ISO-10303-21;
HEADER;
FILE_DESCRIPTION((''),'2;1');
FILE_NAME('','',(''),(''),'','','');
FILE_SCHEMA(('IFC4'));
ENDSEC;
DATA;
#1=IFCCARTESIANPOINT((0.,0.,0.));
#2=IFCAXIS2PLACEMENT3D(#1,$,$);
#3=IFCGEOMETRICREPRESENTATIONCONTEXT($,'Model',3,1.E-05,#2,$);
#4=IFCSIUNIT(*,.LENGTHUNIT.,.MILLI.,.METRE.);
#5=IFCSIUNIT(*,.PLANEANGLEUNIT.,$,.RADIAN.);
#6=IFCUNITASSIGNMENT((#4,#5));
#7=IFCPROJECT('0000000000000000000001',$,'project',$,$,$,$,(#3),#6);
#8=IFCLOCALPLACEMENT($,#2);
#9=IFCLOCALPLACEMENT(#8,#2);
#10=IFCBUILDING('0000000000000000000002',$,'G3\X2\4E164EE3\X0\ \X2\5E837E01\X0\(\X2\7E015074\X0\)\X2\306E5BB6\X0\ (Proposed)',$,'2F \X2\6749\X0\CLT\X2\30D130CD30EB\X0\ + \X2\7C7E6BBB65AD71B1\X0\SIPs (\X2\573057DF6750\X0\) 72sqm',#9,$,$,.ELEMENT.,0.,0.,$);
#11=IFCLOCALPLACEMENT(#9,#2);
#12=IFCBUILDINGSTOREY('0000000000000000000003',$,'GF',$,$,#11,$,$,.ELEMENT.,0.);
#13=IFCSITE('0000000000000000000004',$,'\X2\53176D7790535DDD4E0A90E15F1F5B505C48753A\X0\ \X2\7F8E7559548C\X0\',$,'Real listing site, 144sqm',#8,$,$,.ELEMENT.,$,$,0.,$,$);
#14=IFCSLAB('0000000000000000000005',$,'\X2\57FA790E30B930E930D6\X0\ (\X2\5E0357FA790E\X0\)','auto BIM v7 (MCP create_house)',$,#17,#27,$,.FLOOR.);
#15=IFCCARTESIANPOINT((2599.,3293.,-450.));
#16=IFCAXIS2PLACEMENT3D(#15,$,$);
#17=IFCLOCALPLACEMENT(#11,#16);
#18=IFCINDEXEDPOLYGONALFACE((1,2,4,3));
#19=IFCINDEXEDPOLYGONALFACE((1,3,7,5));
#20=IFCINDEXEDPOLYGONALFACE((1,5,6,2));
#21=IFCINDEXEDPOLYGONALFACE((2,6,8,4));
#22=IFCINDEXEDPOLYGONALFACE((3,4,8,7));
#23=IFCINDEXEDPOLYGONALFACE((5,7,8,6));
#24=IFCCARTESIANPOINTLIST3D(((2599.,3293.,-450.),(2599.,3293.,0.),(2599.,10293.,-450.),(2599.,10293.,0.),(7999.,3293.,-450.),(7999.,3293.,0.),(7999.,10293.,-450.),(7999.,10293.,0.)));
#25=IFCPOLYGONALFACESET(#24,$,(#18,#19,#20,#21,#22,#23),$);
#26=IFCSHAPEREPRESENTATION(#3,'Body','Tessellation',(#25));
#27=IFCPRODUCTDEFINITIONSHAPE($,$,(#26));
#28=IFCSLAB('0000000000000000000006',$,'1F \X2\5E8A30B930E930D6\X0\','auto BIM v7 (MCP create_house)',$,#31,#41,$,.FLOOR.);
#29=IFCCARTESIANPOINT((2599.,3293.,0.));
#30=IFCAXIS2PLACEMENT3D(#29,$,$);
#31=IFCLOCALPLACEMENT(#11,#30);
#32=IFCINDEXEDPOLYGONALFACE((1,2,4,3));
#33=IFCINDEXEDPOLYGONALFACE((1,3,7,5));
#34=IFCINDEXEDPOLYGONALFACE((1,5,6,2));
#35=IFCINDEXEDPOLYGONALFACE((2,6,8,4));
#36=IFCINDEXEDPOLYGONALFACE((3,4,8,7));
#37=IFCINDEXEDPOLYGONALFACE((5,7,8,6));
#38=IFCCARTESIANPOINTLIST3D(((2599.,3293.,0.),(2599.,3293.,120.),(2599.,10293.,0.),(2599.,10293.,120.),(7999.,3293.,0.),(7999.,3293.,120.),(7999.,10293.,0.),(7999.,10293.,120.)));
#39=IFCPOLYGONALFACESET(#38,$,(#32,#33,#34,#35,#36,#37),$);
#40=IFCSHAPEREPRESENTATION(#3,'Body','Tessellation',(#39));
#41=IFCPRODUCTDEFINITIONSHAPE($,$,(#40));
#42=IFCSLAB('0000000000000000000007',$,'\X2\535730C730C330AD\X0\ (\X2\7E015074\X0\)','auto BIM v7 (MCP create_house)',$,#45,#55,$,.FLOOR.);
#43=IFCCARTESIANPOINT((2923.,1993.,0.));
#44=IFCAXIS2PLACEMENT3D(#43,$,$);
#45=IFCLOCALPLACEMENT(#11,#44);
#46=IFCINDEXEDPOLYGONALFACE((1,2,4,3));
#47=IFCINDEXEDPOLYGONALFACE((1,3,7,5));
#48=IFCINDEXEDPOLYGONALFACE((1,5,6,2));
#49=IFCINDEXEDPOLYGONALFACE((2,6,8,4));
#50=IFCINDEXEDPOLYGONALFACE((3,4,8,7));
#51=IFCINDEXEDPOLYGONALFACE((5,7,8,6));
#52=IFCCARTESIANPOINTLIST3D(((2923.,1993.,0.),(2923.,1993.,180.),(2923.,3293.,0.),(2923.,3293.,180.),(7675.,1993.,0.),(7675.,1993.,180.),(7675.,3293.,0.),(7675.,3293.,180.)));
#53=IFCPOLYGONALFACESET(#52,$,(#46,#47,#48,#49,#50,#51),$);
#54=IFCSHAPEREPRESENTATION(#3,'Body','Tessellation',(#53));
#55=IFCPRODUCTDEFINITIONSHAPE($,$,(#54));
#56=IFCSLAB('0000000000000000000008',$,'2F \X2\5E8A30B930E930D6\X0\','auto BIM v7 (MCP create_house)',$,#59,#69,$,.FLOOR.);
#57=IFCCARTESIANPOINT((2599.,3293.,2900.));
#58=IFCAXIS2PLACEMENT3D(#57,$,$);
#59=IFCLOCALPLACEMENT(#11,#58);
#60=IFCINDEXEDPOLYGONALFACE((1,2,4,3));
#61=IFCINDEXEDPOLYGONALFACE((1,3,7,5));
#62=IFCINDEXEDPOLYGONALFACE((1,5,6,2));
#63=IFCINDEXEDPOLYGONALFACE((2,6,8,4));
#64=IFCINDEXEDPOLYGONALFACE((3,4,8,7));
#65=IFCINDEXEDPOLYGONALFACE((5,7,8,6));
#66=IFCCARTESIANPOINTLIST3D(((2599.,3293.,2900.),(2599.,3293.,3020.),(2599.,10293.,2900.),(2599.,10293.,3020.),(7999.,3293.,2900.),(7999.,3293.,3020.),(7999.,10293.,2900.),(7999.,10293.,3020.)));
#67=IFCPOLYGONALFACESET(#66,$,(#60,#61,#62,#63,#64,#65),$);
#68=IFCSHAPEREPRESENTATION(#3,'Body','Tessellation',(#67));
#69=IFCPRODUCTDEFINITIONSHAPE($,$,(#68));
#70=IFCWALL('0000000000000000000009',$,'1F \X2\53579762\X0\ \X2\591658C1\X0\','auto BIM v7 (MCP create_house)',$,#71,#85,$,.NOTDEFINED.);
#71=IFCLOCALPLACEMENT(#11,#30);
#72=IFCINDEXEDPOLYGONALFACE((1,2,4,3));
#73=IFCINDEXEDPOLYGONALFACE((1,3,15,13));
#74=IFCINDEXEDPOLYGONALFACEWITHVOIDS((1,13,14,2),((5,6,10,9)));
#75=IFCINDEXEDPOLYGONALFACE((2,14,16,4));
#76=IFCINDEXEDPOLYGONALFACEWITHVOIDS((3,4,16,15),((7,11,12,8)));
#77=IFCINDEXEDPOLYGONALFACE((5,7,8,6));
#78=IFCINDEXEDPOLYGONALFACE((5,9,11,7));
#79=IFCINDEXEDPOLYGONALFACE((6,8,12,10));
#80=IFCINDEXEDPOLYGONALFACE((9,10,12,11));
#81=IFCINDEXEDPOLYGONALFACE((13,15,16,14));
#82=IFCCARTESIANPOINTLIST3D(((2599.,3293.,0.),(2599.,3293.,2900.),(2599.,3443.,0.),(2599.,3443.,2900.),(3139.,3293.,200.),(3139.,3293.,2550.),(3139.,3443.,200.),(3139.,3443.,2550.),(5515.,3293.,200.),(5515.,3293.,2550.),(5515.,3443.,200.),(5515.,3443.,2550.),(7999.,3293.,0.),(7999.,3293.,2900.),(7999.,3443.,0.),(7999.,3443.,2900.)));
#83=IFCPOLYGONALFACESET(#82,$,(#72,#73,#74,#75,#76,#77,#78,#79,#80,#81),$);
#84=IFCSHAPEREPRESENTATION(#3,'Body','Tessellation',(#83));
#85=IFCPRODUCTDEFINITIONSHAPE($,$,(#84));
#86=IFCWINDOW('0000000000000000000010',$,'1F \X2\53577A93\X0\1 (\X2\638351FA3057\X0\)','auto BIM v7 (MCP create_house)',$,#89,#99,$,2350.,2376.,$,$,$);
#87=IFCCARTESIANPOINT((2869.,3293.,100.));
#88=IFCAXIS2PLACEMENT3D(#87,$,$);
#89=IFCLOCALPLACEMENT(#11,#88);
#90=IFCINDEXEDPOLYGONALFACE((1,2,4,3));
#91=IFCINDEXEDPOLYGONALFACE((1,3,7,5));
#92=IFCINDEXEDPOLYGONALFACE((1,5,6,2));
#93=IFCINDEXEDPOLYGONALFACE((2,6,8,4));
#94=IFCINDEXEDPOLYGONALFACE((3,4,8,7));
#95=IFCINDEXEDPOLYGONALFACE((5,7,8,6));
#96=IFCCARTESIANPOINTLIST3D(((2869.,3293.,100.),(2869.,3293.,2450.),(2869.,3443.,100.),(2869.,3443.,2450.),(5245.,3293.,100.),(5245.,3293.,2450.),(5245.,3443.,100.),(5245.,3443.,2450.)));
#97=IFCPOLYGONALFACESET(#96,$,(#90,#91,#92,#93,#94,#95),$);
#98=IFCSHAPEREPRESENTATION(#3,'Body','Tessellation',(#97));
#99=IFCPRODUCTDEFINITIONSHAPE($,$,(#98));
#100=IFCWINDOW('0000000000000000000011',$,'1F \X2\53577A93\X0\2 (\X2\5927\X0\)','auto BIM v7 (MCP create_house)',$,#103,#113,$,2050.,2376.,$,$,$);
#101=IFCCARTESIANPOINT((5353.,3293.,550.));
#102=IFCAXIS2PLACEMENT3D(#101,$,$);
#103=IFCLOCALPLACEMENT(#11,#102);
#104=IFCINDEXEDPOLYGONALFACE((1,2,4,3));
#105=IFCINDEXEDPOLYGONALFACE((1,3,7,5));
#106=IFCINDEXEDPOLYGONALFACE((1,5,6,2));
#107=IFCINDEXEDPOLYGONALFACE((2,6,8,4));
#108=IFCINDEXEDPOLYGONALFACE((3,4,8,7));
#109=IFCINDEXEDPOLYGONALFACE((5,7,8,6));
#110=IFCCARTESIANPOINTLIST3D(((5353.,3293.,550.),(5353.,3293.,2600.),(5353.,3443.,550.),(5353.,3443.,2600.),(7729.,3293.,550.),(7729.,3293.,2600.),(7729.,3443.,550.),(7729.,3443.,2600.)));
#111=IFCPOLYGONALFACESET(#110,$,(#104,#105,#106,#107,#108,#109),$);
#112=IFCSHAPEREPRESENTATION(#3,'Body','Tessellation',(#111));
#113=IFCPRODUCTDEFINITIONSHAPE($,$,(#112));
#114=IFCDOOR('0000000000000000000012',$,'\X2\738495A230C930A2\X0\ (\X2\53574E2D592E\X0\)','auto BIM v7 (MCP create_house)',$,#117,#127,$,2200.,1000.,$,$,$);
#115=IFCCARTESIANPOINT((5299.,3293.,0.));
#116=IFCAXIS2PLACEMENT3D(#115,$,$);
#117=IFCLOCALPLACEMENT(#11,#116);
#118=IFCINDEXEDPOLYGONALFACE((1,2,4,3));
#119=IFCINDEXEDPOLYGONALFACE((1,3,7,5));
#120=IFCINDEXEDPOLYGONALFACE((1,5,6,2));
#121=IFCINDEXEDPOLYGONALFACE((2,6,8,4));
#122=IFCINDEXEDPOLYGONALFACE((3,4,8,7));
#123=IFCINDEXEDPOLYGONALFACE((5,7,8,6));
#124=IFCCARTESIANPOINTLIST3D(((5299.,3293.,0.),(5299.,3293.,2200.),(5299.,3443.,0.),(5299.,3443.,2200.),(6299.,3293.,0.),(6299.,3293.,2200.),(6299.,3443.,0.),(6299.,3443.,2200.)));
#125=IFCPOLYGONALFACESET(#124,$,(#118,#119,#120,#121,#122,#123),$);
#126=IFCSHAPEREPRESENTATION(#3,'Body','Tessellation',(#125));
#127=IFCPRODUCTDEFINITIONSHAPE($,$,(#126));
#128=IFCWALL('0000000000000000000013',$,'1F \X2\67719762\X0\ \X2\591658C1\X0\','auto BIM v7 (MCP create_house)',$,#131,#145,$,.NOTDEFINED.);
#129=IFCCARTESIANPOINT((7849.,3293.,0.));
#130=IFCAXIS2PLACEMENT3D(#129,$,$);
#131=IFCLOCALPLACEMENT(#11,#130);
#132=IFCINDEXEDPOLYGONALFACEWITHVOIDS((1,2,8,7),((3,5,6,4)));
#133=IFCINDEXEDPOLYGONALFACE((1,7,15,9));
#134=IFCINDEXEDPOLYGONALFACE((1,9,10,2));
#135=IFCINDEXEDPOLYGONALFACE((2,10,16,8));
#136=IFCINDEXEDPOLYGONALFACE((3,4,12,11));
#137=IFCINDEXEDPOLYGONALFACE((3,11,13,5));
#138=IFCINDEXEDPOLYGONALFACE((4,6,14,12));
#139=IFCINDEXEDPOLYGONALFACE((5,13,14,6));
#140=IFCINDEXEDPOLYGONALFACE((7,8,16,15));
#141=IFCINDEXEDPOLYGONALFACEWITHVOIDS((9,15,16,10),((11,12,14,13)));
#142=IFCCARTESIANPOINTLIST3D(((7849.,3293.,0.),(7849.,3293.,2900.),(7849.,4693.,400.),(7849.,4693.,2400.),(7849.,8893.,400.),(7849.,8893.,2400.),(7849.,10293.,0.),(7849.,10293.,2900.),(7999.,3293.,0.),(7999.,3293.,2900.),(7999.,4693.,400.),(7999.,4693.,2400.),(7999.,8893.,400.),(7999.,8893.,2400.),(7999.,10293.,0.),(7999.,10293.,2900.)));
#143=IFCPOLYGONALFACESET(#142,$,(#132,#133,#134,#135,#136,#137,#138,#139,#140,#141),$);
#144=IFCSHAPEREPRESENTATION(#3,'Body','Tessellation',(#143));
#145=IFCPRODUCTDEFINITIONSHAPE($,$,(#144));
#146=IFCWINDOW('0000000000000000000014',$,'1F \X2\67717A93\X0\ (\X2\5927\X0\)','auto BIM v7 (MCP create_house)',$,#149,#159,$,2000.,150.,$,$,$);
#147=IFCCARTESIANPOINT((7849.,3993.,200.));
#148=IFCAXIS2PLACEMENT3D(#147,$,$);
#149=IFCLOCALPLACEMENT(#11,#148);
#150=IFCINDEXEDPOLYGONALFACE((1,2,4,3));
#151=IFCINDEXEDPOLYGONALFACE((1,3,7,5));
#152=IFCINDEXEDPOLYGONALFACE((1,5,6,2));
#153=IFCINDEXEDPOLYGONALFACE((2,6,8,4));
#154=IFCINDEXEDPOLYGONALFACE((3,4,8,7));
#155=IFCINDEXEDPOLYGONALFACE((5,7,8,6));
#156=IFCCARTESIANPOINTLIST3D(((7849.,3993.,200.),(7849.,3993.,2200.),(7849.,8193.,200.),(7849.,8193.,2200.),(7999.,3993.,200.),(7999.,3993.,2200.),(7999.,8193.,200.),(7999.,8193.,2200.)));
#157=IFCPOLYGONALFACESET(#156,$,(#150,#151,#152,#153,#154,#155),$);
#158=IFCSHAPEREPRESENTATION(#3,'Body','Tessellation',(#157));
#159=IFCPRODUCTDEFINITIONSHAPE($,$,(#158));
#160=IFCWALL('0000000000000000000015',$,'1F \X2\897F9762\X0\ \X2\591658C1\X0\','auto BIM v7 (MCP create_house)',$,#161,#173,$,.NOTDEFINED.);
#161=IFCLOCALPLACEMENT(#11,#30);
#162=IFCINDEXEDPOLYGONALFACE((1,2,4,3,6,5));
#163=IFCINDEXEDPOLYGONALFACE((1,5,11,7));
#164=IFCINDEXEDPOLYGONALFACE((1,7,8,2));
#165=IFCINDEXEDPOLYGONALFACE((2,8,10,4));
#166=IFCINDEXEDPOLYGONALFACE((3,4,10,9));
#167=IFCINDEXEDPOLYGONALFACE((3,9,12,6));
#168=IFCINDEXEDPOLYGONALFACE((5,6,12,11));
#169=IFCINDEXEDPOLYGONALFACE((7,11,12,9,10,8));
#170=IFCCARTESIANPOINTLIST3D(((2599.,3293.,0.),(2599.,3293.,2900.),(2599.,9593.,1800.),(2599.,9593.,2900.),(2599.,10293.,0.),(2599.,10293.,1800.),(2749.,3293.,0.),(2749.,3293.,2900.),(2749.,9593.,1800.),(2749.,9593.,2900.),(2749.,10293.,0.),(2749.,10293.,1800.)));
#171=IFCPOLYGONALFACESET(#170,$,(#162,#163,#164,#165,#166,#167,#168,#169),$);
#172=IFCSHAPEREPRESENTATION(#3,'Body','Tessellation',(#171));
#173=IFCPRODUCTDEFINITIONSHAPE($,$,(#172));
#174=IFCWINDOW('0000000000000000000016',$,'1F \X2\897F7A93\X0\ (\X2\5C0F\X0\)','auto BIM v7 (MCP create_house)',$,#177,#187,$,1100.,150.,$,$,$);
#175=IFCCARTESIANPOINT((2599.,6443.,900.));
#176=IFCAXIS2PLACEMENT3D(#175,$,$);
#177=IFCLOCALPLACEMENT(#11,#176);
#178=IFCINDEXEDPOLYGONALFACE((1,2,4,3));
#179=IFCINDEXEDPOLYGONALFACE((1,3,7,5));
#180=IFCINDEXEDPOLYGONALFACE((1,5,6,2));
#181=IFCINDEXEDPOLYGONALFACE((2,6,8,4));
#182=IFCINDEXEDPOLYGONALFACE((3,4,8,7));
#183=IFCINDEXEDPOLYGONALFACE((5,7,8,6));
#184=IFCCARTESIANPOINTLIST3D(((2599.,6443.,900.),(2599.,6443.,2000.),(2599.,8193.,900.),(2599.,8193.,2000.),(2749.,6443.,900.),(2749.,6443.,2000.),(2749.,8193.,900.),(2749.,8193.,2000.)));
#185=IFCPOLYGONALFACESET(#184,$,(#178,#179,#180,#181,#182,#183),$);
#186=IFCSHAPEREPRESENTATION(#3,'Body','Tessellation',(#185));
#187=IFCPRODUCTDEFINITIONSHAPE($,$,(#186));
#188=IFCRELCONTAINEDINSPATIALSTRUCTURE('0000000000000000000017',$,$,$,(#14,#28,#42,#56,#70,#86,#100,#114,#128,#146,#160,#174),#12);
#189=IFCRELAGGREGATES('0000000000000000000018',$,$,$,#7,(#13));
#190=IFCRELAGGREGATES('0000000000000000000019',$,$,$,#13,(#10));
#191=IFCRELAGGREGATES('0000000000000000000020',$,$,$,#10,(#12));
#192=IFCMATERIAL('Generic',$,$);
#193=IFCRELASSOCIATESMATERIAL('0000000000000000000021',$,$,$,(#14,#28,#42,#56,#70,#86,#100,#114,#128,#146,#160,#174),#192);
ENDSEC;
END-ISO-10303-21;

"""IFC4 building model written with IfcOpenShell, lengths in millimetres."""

from ifc_helpers import new_model, si_unit, frame, frame_2d, origin, place, context, project, spatial, rectangle, extrude, material, element, fill, save


model = new_model("IFC4")

# Units and contexts
model_context = context("Model", 3, precision=1e-05, world=origin())
ifc_project = project(units=[si_unit("LENGTHUNIT", "METRE", prefix="MILLI"), si_unit("PLANEANGLEUNIT", "RADIAN")], contexts=[model_context])

# Site, building, storey
site_placement = place(None, origin())
site = spatial("IfcSite", under=ifc_project, at=site_placement, Name="北海道川上郡弟子屈町 美留和", ObjectType="Real listing site, 144sqm", CompositionType="ELEMENT", RefElevation=0.0)
building_placement = place(site_placement, origin())
building = spatial("IfcBuilding", under=site, at=building_placement, Name="G3世代 広縁(縁側)の家 (Proposed)", ObjectType="2F 杉CLTパネル + 籾殻断熱SIPs (地域材) 72sqm", CompositionType="ELEMENT", ElevationOfRefHeight=0.0, ElevationOfTerrain=0.0)
storey_placement = place(building_placement, origin())
storey = spatial("IfcBuildingStorey", under=building, at=storey_placement, Name="GF", CompositionType="ELEMENT", Elevation=0.0)

# Slabs
ifc_material = material(Name="Generic")
slab_1_placement = place(storey_placement, frame((2599.0, 3293.0, -450.0)))
element("IfcSlab", 1, at=slab_1_placement, inside=storey, material=ifc_material, Name="基礎スラブ (布基礎)", Description="auto BIM v7 (MCP create_house)", PredefinedType="FLOOR", context=model_context, shape_type="SweptSolid", body=[
    extrude(rectangle(XDim=5400.0, YDim=7000.0, at=frame_2d((2700.0, 3500.0))), frame((2599.0, 3293.0, -450.0)), (0.0, 0.0, 1.0), 450.0),
])
slab_2_placement = place(storey_placement, frame((2599.0, 3293.0, 0.0)))
element("IfcSlab", 2, at=slab_2_placement, inside=storey, material=ifc_material, Name="1F 床スラブ", Description="auto BIM v7 (MCP create_house)", PredefinedType="FLOOR", context=model_context, shape_type="SweptSolid", body=[
    extrude(rectangle(XDim=5400.0, YDim=7000.0, at=frame_2d((2700.0, 3500.0))), frame((2599.0, 3293.0, 0.0)), (0.0, 0.0, 1.0), 120.0),
])
slab_3_placement = place(storey_placement, frame((2923.0, 1993.0, 0.0)))
element("IfcSlab", 3, at=slab_3_placement, inside=storey, material=ifc_material, Name="南デッキ (縁側)", Description="auto BIM v7 (MCP create_house)", PredefinedType="FLOOR", context=model_context, shape_type="SweptSolid", body=[
    extrude(rectangle(XDim=4752.0, YDim=1300.0, at=frame_2d((2376.0, 650.0))), frame((2923.0, 1993.0, 0.0)), (0.0, 0.0, 1.0), 180.0),
])
slab_4_placement = place(storey_placement, frame((2599.0, 3293.0, 2900.0)))
element("IfcSlab", 4, at=slab_4_placement, inside=storey, material=ifc_material, Name="2F 床スラブ", Description="auto BIM v7 (MCP create_house)", PredefinedType="FLOOR", context=model_context, shape_type="SweptSolid", body=[
    extrude(rectangle(XDim=5400.0, YDim=7000.0, at=frame_2d((2700.0, 3500.0))), frame((2599.0, 3293.0, 2900.0)), (0.0, 0.0, 1.0), 120.0),
])

# Wall, openings, windows, door
wall_1_placement = place(storey_placement, frame((2599.0, 3293.0, 0.0)))
wall_1 = element("IfcWall", 5, at=wall_1_placement, inside=storey, material=ifc_material, Name="1F 南面 外壁", Description="auto BIM v7 (MCP create_house)", PredefinedType="NOTDEFINED", context=model_context, shape_type="SweptSolid", body=[
    extrude(rectangle(XDim=5400.0, YDim=150.0, at=frame_2d((2700.0, 75.0))), frame((2599.0, 3293.0, 0.0)), (0.0, 0.0, 1.0), 2900.0),
])
opening_1_placement = place(storey_placement, frame((2869.0, 3293.0, 100.0)))
opening_1 = element("IfcOpeningElement", 6, at=opening_1_placement, cuts=wall_1, PredefinedType="NOTDEFINED", context=model_context, shape_type="SweptSolid", body=[
    extrude(rectangle(XDim=2376.0, YDim=150.0, at=frame_2d((1188.0, 75.0))), frame((2869.0, 3293.0, 100.0)), (0.0, 0.0, 1.0), 2350.0),
])
opening_2_placement = place(storey_placement, frame((5353.0, 3293.0, 550.0)))
opening_2 = element("IfcOpeningElement", 7, at=opening_2_placement, cuts=wall_1, PredefinedType="NOTDEFINED", context=model_context, shape_type="SweptSolid", body=[
    extrude(rectangle(XDim=2376.0, YDim=150.0, at=frame_2d((1188.0, 75.0))), frame((5353.0, 3293.0, 550.0)), (0.0, 0.0, 1.0), 2050.0),
])
opening_3_placement = place(storey_placement, frame((5299.0, 3293.0, 0.0)))
opening_3 = element("IfcOpeningElement", 8, at=opening_3_placement, cuts=wall_1, PredefinedType="NOTDEFINED", context=model_context, shape_type="SweptSolid", body=[
    extrude(rectangle(XDim=1000.0, YDim=150.0, at=frame_2d((500.0, 75.0))), frame((5299.0, 3293.0, 0.0)), (0.0, 0.0, 1.0), 2200.0),
])
window_1_placement = place(storey_placement, frame((2869.0, 3293.0, 100.0)))
window_1 = element("IfcWindow", 9, at=window_1_placement, inside=storey, material=ifc_material, Name="1F 南窓1 (掃出し)", Description="auto BIM v7 (MCP create_house)", OverallHeight=2350.0, OverallWidth=2376.0, context=model_context, shape_type="SweptSolid", body=[
    extrude(rectangle(XDim=2376.0, YDim=150.0, at=frame_2d((1188.0, 75.0))), frame((2869.0, 3293.0, 100.0)), (0.0, 0.0, 1.0), 2350.0),
])
fill(opening_1, window_1)
window_2_placement = place(storey_placement, frame((5353.0, 3293.0, 550.0)))
window_2 = element("IfcWindow", 10, at=window_2_placement, inside=storey, material=ifc_material, Name="1F 南窓2 (大)", Description="auto BIM v7 (MCP create_house)", OverallHeight=2050.0, OverallWidth=2376.0, context=model_context, shape_type="SweptSolid", body=[
    extrude(rectangle(XDim=2376.0, YDim=150.0, at=frame_2d((1188.0, 75.0))), frame((5353.0, 3293.0, 550.0)), (0.0, 0.0, 1.0), 2050.0),
])
fill(opening_2, window_2)
door_placement = place(storey_placement, frame((5299.0, 3293.0, 0.0)))
door = element("IfcDoor", 11, at=door_placement, inside=storey, material=ifc_material, Name="玄関ドア (南中央)", Description="auto BIM v7 (MCP create_house)", OverallHeight=2200.0, OverallWidth=1000.0, context=model_context, shape_type="SweptSolid", body=[
    extrude(rectangle(XDim=1000.0, YDim=150.0, at=frame_2d((500.0, 75.0))), frame((5299.0, 3293.0, 0.0)), (0.0, 0.0, 1.0), 2200.0),
])
fill(opening_3, door)

# Walls, openings, windows
wall_2_placement = place(storey_placement, frame((7849.0, 3293.0, 0.0)))
wall_2 = element("IfcWall", 12, at=wall_2_placement, inside=storey, material=ifc_material, Name="1F 東面 外壁", Description="auto BIM v7 (MCP create_house)", PredefinedType="NOTDEFINED", context=model_context, shape_type="SweptSolid", body=[
    extrude(rectangle(XDim=150.0, YDim=7000.0, at=frame_2d((75.0, 3500.0))), frame((7849.0, 3293.0, 0.0)), (0.0, 0.0, 1.0), 2900.0),
])
opening_4_placement = place(storey_placement, frame((7849.0, 3993.0, 200.0)))
opening_4 = element("IfcOpeningElement", 13, at=opening_4_placement, cuts=wall_2, PredefinedType="NOTDEFINED", context=model_context, shape_type="SweptSolid", body=[
    extrude(rectangle(XDim=150.0, YDim=4200.0, at=frame_2d((75.0, 2100.0))), frame((7849.0, 3993.0, 200.0)), (0.0, 0.0, 1.0), 2000.0),
])
window_3_placement = place(storey_placement, frame((7849.0, 3993.0, 200.0)))
window_3 = element("IfcWindow", 14, at=window_3_placement, inside=storey, material=ifc_material, Name="1F 東窓 (大)", Description="auto BIM v7 (MCP create_house)", OverallHeight=2000.0, OverallWidth=150.0, context=model_context, shape_type="SweptSolid", body=[
    extrude(rectangle(XDim=150.0, YDim=4200.0, at=frame_2d((75.0, 2100.0))), frame((7849.0, 3993.0, 200.0)), (0.0, 0.0, 1.0), 2000.0),
])
fill(opening_4, window_3)
wall_3_placement = place(storey_placement, frame((2599.0, 3293.0, 0.0)))
wall_3 = element("IfcWall", 15, at=wall_3_placement, inside=storey, material=ifc_material, Name="1F 西面 外壁", Description="auto BIM v7 (MCP create_house)", PredefinedType="NOTDEFINED", context=model_context, shape_type="SweptSolid", body=[
    extrude(rectangle(XDim=150.0, YDim=7000.0, at=frame_2d((75.0, 3500.0))), frame((2599.0, 3293.0, 0.0)), (0.0, 0.0, 1.0), 2900.0),
])
opening_5_placement = place(storey_placement, frame((2599.0, 6443.0, 900.0)))
opening_5 = element("IfcOpeningElement", 16, at=opening_5_placement, cuts=wall_3, PredefinedType="NOTDEFINED", context=model_context, shape_type="SweptSolid", body=[
    extrude(rectangle(XDim=150.0, YDim=1750.0, at=frame_2d((75.0, 875.0))), frame((2599.0, 6443.0, 900.0)), (0.0, 0.0, 1.0), 1100.0),
])
window_4_placement = place(storey_placement, frame((2599.0, 6443.0, 900.0)))
window_4 = element("IfcWindow", 17, at=window_4_placement, inside=storey, material=ifc_material, Name="1F 西窓 (小)", Description="auto BIM v7 (MCP create_house)", OverallHeight=1100.0, OverallWidth=150.0, context=model_context, shape_type="SweptSolid", body=[
    extrude(rectangle(XDim=150.0, YDim=1750.0, at=frame_2d((75.0, 875.0))), frame((2599.0, 6443.0, 900.0)), (0.0, 0.0, 1.0), 1100.0),
])
fill(opening_5, window_4)

save(model, "model.ifc")
